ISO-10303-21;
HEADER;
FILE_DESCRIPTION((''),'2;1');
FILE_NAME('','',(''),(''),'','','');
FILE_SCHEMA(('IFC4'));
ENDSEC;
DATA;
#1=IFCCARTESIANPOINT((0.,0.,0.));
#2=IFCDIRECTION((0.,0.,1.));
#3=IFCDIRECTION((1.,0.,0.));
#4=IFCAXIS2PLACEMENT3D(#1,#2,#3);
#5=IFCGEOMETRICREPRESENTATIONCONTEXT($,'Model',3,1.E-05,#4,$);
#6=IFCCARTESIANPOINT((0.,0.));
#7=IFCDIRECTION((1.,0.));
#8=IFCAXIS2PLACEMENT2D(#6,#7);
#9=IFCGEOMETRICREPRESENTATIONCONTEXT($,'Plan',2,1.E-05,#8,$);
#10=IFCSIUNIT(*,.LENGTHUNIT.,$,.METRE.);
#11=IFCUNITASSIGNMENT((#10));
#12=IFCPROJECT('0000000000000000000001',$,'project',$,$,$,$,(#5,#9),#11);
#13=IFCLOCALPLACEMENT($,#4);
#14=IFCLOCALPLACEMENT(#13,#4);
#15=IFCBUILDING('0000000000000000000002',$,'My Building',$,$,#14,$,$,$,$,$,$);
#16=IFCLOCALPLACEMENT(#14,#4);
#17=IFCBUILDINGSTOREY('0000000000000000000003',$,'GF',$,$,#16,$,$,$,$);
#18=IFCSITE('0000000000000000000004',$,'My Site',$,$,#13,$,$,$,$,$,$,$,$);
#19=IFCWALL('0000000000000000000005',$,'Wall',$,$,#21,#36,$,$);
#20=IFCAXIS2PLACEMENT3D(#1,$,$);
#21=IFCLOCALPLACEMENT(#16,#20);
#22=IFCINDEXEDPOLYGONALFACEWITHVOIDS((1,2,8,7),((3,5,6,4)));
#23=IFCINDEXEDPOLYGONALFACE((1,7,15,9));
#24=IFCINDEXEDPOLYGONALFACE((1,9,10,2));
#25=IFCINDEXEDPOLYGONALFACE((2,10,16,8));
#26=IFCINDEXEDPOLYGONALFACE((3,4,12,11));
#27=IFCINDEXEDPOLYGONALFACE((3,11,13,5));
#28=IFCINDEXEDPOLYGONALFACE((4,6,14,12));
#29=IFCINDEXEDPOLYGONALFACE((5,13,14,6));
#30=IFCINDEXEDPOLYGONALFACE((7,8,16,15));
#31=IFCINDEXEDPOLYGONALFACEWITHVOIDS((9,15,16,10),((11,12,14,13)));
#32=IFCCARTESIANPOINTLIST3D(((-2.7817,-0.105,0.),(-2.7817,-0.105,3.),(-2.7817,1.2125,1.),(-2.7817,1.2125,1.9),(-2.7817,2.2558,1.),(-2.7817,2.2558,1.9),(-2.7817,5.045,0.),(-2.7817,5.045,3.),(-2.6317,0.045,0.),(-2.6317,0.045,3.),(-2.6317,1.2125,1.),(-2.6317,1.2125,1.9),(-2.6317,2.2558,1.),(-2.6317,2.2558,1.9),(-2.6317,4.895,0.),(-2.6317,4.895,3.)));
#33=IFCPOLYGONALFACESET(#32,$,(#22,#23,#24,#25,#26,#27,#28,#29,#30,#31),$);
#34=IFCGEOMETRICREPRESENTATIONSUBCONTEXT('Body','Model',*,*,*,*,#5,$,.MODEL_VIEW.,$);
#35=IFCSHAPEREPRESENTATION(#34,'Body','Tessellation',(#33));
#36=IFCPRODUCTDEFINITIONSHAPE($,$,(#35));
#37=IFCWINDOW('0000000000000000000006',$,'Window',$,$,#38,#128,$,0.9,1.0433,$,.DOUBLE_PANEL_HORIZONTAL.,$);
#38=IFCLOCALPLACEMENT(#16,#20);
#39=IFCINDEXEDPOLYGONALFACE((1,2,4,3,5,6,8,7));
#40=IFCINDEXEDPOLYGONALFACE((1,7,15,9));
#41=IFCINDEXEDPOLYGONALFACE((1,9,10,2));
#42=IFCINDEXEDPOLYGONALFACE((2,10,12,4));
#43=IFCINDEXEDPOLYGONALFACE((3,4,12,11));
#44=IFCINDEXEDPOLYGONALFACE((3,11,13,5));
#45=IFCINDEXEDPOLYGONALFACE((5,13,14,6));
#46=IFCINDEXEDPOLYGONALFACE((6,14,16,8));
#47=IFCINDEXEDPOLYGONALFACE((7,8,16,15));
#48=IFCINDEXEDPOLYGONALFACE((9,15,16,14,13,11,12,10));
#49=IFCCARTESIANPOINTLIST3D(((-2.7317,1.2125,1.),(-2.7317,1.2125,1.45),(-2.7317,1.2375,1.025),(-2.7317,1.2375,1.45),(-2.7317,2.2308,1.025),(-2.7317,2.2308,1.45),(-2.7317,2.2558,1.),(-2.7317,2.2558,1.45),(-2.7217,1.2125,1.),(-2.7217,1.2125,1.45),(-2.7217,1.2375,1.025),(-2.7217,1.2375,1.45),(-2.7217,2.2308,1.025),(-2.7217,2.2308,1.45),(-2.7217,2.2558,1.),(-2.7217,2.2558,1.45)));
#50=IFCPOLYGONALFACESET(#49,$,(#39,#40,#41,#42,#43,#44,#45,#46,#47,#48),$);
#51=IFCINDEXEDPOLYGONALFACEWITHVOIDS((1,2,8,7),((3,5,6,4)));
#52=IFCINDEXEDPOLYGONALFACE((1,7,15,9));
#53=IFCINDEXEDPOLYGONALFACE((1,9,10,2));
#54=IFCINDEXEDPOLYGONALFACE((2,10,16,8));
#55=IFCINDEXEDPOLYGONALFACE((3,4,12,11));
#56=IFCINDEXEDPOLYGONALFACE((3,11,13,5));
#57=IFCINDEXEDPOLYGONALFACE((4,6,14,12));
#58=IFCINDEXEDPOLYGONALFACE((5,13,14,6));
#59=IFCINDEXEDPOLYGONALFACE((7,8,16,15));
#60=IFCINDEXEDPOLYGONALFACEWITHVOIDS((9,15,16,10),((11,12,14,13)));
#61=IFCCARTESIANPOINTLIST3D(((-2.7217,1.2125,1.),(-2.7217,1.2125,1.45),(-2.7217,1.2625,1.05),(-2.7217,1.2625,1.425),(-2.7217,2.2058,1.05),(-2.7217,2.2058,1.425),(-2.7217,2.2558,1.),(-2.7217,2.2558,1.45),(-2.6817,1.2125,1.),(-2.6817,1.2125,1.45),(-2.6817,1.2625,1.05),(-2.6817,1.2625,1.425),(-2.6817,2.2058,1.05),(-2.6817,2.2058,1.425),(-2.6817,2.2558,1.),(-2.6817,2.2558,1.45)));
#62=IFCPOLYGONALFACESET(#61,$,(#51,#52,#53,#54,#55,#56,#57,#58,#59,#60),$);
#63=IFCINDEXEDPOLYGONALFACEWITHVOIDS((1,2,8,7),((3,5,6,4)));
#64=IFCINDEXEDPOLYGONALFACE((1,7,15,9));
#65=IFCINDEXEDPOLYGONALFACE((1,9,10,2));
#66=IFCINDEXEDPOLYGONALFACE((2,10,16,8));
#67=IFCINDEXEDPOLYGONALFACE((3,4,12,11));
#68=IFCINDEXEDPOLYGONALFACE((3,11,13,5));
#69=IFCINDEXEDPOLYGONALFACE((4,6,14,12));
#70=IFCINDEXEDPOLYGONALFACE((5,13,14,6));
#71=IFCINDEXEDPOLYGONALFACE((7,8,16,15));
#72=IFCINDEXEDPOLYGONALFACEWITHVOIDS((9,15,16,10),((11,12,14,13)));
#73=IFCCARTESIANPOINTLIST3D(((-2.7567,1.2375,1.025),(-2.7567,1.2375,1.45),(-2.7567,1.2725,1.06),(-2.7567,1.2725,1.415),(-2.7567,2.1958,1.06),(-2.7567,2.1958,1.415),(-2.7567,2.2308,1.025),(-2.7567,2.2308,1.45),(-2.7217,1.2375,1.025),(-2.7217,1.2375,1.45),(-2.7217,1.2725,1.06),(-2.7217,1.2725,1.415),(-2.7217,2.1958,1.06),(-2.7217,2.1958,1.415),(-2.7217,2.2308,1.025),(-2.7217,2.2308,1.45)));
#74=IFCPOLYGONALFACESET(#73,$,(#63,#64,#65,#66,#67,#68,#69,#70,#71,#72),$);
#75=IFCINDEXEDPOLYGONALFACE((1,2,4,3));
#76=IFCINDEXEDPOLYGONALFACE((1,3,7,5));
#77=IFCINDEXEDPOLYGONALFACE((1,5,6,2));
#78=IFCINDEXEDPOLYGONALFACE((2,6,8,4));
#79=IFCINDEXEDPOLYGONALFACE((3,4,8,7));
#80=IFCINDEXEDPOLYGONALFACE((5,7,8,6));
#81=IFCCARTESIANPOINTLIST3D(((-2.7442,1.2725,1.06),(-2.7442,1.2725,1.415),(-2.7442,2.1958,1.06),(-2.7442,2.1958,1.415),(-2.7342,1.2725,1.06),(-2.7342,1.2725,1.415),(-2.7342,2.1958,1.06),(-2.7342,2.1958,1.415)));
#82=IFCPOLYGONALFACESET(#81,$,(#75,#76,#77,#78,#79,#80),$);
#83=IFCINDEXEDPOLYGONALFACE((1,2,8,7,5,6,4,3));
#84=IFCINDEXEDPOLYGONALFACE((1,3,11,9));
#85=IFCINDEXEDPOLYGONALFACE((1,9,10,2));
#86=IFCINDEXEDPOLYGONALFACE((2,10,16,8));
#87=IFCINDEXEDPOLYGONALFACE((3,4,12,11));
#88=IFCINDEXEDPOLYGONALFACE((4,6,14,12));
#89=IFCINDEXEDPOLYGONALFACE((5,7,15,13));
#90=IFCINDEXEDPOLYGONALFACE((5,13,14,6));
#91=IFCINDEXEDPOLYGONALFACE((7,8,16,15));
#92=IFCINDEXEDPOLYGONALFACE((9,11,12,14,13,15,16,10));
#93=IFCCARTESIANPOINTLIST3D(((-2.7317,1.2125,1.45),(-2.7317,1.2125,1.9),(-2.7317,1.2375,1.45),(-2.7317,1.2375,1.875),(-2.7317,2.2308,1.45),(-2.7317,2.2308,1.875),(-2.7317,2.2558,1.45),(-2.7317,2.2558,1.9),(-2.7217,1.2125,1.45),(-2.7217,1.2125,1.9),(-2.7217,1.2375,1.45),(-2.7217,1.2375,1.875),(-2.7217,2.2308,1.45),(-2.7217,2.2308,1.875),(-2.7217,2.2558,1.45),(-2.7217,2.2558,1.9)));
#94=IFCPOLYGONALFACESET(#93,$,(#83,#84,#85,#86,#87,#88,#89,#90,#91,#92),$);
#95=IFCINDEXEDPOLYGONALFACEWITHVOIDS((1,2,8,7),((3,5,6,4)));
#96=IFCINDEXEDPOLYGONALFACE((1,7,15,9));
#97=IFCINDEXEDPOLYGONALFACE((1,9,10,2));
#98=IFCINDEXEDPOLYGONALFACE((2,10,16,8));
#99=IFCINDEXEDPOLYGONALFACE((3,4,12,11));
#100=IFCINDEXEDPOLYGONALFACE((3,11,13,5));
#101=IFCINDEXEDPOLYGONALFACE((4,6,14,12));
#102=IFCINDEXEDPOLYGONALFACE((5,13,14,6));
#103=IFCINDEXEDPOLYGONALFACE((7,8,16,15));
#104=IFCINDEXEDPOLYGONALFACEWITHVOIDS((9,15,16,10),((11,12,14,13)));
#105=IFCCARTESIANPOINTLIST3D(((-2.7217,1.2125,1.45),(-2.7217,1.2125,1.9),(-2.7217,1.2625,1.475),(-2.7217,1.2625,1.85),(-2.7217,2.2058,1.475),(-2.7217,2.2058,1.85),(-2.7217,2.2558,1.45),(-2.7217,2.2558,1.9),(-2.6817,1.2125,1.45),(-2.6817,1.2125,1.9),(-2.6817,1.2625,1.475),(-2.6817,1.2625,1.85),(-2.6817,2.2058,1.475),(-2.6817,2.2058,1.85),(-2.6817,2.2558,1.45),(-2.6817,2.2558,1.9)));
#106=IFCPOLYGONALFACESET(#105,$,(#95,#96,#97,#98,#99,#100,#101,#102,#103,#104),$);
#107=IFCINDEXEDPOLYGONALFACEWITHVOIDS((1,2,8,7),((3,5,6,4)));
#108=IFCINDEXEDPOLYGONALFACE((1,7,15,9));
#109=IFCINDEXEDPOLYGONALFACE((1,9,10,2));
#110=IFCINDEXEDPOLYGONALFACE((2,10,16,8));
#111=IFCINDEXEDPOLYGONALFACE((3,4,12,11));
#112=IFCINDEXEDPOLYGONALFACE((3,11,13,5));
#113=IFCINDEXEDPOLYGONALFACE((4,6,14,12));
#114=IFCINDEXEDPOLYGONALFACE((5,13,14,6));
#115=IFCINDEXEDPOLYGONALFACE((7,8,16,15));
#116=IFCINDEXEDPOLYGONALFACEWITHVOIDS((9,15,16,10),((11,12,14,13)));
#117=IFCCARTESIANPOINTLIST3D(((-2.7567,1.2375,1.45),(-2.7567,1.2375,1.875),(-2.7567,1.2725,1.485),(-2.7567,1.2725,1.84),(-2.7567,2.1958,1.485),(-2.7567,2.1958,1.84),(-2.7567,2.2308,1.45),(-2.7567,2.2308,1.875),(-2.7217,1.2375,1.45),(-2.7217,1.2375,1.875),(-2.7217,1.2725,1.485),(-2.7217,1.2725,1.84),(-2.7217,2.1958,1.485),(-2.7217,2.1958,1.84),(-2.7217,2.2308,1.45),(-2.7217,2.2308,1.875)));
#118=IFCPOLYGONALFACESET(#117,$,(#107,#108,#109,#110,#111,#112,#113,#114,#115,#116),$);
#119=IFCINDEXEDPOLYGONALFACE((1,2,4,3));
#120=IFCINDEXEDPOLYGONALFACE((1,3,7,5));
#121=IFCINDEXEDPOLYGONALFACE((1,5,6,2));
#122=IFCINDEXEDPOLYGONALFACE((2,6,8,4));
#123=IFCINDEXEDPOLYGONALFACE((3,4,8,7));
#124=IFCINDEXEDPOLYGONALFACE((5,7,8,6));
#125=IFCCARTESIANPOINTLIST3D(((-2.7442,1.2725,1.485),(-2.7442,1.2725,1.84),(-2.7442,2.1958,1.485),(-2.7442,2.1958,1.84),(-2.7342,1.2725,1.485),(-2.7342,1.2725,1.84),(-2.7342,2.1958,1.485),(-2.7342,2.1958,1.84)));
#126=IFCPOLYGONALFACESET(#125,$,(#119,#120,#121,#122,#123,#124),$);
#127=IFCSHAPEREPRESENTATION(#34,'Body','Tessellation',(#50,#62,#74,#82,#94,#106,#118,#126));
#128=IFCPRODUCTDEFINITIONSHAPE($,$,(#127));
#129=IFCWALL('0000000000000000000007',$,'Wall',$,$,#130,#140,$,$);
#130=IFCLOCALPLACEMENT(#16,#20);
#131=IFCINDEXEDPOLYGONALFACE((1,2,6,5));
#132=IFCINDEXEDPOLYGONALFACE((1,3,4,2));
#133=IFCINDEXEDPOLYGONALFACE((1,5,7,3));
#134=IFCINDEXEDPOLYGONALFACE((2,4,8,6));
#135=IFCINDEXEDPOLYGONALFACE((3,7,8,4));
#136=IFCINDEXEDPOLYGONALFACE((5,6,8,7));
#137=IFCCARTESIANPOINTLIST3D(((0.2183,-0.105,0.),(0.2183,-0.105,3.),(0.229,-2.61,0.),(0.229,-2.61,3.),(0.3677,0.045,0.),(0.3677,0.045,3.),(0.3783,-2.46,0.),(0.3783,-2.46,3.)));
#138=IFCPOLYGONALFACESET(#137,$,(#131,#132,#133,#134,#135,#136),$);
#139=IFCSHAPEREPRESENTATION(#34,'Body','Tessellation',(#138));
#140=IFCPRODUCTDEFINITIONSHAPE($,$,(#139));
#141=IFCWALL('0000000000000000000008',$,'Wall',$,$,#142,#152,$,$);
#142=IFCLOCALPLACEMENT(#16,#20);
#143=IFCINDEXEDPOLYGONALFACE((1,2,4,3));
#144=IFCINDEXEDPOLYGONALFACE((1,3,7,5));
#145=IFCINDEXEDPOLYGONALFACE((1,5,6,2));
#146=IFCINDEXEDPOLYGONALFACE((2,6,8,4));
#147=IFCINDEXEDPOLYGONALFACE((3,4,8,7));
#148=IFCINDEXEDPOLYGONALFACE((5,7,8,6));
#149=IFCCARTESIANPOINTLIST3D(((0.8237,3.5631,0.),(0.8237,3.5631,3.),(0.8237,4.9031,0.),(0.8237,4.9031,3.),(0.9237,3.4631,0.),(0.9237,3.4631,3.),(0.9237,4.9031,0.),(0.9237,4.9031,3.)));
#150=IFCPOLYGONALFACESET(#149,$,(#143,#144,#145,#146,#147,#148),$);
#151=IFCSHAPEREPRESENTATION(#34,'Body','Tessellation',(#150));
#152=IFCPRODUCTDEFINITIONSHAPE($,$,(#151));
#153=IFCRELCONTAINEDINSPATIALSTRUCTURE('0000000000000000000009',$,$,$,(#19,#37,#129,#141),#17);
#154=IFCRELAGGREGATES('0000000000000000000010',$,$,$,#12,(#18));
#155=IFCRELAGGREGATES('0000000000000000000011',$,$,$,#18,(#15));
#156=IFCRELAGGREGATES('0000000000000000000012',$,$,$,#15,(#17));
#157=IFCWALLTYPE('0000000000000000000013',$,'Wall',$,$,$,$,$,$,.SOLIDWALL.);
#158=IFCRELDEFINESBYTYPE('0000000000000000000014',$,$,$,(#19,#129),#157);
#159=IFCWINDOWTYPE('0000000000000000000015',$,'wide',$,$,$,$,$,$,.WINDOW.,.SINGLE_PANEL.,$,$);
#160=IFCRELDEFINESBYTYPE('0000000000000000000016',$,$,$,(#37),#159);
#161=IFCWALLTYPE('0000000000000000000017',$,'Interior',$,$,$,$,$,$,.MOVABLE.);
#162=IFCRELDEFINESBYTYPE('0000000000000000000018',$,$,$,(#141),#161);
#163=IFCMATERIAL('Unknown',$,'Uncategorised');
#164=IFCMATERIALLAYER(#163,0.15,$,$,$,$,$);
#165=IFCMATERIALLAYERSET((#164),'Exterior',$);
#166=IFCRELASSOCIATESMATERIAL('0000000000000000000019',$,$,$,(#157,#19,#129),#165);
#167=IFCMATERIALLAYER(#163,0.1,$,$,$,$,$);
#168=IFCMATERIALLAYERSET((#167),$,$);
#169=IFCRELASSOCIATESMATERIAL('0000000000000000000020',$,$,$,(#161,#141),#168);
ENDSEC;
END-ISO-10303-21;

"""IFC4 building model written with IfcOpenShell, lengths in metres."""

from ifc_helpers import new_model, entity, si_unit, frame, origin_with_axes, origin_2d_with_axis, place, context, subcontext, project, spatial, line, indexed_curve, outline, extrude, shape, source, transform, mapped, material, layer, layer_set, layer_usage, type_object, type_shapes, element, fill, save


model = new_model("IFC4")

# Units and contexts
model_context = context("Model", 3, precision=1e-05, world=origin_with_axes())
plan_context = context("Plan", 2, precision=1e-05, world=origin_2d_with_axis())
body_context_1 = subcontext(model_context, "Body", "Model", "MODEL_VIEW")
body_context_2 = subcontext(plan_context, "Body", "Plan", "PLAN_VIEW")
ifc_project = project(units=[si_unit("LENGTHUNIT", "METRE")], contexts=[model_context, plan_context])

# Site, building, storey
site_placement = place(None, origin_with_axes())
site = spatial("IfcSite", under=ifc_project, at=site_placement, Name="My Site")
building_placement = place(site_placement, origin_with_axes())
building = spatial("IfcBuilding", under=site, at=building_placement, Name="My Building")
storey_placement = place(building_placement, origin_with_axes())
storey = spatial("IfcBuildingStorey", under=building, at=storey_placement, Name="GF")

# Shared definitions
ifc_material = material(Name="Unknown", Category="Uncategorised")

# Shared definitions
ifc_layer_1 = layer(ifc_material, 0.15)
ifc_layer_set_1 = layer_set([ifc_layer_1], Name="Exterior")
wall_type_1 = type_object("IfcWallType", Name="Wall", PredefinedType="SOLIDWALL", material=ifc_layer_set_1)
shared_shape_1 = source(origin_with_axes(), body_context_1, "Body", "SweptSolid", [
    extrude(outline(indexed_curve([(0.0, 0.0), (1.0433, 0.0), (1.0433, 0.9), (0.0, 0.9)], segments=[line(1, 2, 3, 4, 1)])), frame((0.0, -0.6, 0.0), z_axis=(0.0, -1.0, 0.0), x_axis=(1.0, 0.0, 0.0)), (0.0, 0.0, -1.0), 1.2),
])
window_type_1 = type_object("IfcWindowType", Name="wide", PartitioningType="SINGLE_PANEL", PredefinedType="WINDOW")
shared_shape_2 = source(origin_with_axes(), body_context_1, "Body", "SweptSolid", [
    extrude(outline(indexed_curve([(1.0433, 0.45), (1.0433, 0.0), (0.0, 0.0), (0.0, 0.45), (0.025, 0.45), (0.025, 0.025), (1.0183, 0.025), (1.0183, 0.45)], segments=[line(1, 2, 3, 4, 5, 6, 7, 8, 1)])), frame((0.0, 0.09, 0.0), z_axis=(0.0, -1.0, 0.0), x_axis=(1.0, 0.0, 0.0)), (0.0, 0.0, -1.0), 0.01),
    extrude(outline(indexed_curve([(0.0, 0.0), (1.0433, 0.0), (1.0433, 0.45), (0.0, 0.45)], segments=[line(1, 2, 3, 4, 1)]), holes=[indexed_curve([(0.05, 0.05), (0.9933, 0.05), (0.9933, 0.425), (0.05, 0.425)], segments=[line(1, 2, 3, 4, 1)])]), frame((0.0, 0.05, 0.0), z_axis=(0.0, -1.0, 0.0), x_axis=(1.0, 0.0, 0.0)), (0.0, 0.0, -1.0), 0.04),
    extrude(outline(indexed_curve([(0.0, 0.0), (0.9933, 0.0), (0.9933, 0.425), (0.0, 0.425)], segments=[line(1, 2, 3, 4, 1)]), holes=[indexed_curve([(0.035, 0.035), (0.9583, 0.035), (0.9583, 0.39), (0.035, 0.39)], segments=[line(1, 2, 3, 4, 1)])]), frame((0.025, 0.09, 0.025), z_axis=(0.0, -1.0, 0.0), x_axis=(1.0, 0.0, 0.0)), (0.0, 0.0, -1.0), 0.035),
    extrude(outline(indexed_curve([(0.035, 0.035), (0.9583, 0.035), (0.9583, 0.39), (0.035, 0.39)], segments=[line(1, 2, 3, 4, 1)])), frame((0.025, 0.1025, 0.025), z_axis=(0.0, -1.0, 0.0), x_axis=(1.0, 0.0, 0.0)), (0.0, 0.0, -1.0), 0.01),
    extrude(outline(indexed_curve([(0.0, 0.0), (0.0, 0.45), (1.0433, 0.45), (1.0433, 0.0), (1.0183, 0.0), (1.0183, 0.425), (0.025, 0.425), (0.025, 0.0)], segments=[line(1, 2, 3, 4, 5, 6, 7, 8, 1)])), frame((0.0, 0.09, 0.45), z_axis=(0.0, -1.0, 0.0), x_axis=(1.0, 0.0, 0.0)), (0.0, 0.0, -1.0), 0.01),
    extrude(outline(indexed_curve([(0.0, 0.0), (1.0433, 0.0), (1.0433, 0.45), (0.0, 0.45)], segments=[line(1, 2, 3, 4, 1)]), holes=[indexed_curve([(0.05, 0.025), (0.9933, 0.025), (0.9933, 0.4), (0.05, 0.4)], segments=[line(1, 2, 3, 4, 1)])]), frame((0.0, 0.05, 0.45), z_axis=(0.0, -1.0, 0.0), x_axis=(1.0, 0.0, 0.0)), (0.0, 0.0, -1.0), 0.04),
    extrude(outline(indexed_curve([(0.0, 0.0), (0.9933, 0.0), (0.9933, 0.425), (0.0, 0.425)], segments=[line(1, 2, 3, 4, 1)]), holes=[indexed_curve([(0.035, 0.035), (0.9583, 0.035), (0.9583, 0.39), (0.035, 0.39)], segments=[line(1, 2, 3, 4, 1)])]), frame((0.025, 0.09, 0.45), z_axis=(0.0, -1.0, 0.0), x_axis=(1.0, 0.0, 0.0)), (0.0, 0.0, -1.0), 0.035),
    extrude(outline(indexed_curve([(0.035, 0.035), (0.9583, 0.035), (0.9583, 0.39), (0.035, 0.39)], segments=[line(1, 2, 3, 4, 1)])), frame((0.025, 0.1025, 0.45), z_axis=(0.0, -1.0, 0.0), x_axis=(1.0, 0.0, 0.0)), (0.0, 0.0, -1.0), 0.01),
])
shared_shape_3 = source(origin_with_axes(), body_context_2, "Body", "Curve2D", [
    entity("IfcIndexedPolyCurve", entity("IfcCartesianPointList2D", [[0.05, 0.05], [0.9933, 0.05]])),
    entity("IfcIndexedPolyCurve", entity("IfcCartesianPointList2D", [[0.0, 0.1], [0.025, 0.1], [0.025, 0.09], [0.05, 0.09], [0.05, 0.05], [0.0, 0.05]]), [entity("IfcLineIndex", [1, 2, 3, 4, 5, 6, 1])]),
    entity("IfcIndexedPolyCurve", entity("IfcCartesianPointList2D", [[1.0433, 0.1], [1.0183, 0.1], [1.0183, 0.09], [0.9933, 0.09], [0.9933, 0.05], [1.0433, 0.05]]), [entity("IfcLineIndex", [1, 2, 3, 4, 5, 6, 1])]),
    entity("IfcIndexedPolyCurve", entity("IfcCartesianPointList2D", [[0.025, 0.09], [0.06, 0.09], [0.06, 0.125], [0.025, 0.125]]), [entity("IfcLineIndex", [1, 2, 3, 4, 1])]),
    entity("IfcIndexedPolyCurve", entity("IfcCartesianPointList2D", [[1.0183, 0.09], [0.9833, 0.09], [0.9833, 0.125], [1.0183, 0.125]]), [entity("IfcLineIndex", [1, 2, 3, 4, 1])]),
    entity("IfcIndexedPolyCurve", entity("IfcCartesianPointList2D", [[0.06, 0.09], [0.9833, 0.09]])),
    entity("IfcIndexedPolyCurve", entity("IfcCartesianPointList2D", [[0.06, 0.125], [0.9833, 0.125]])),
    entity("IfcIndexedPolyCurve", entity("IfcCartesianPointList2D", [[0.06, 0.1075], [0.9833, 0.1075]])),
])
type_shapes(window_type_1, [shared_shape_2, shared_shape_3])

# Wall, opening, window
ifc_layer_usage_1 = layer_usage(ifc_layer_set_1, "AXIS2", "POSITIVE", 0.0)
wall_1_placement = place(storey_placement, frame((-2.7817, 5.045, 0.0), z_axis=(0.0, 0.0, 1.0), x_axis=(0.0, -1.0, 0.0)))
wall_1 = element("IfcWall", 1, at=wall_1_placement, inside=storey, type_object=wall_type_1, material=ifc_layer_usage_1, Name="Wall", context=body_context_1, shape_type="SweptSolid", body=[
    extrude(outline(indexed_curve([(0.0, 0.0), (0.15, 0.15), (5.0, 0.15), (5.15, 0.0)], segments=[line(1, 2, 3, 4, 1)])), origin_with_axes(), (0.0, 0.0, 1.0), 3.0),
])
opening_1_placement = place(wall_1_placement, frame((3.8324, 0.15, 1.0), z_axis=(0.0, 0.0, 1.0), x_axis=(-1.0, 0.0, 0.0)))
opening_1 = element("IfcOpeningElement", 2, at=opening_1_placement, cuts=wall_1, PredefinedType="OPENING", context=body_context_1, shape_type="MappedRepresentation", body=[
    mapped(shared_shape_1, transform((0.0, 0.0, 0.0), x_axis=(1.0, 0.0, 0.0), y_axis=(0.0, 1.0, 0.0), z_axis=(0.0, 0.0, 1.0), scale=1.0)),
])
window_1_placement = place(opening_1_placement, frame((0.0, 0.0, 0.0), z_axis=(0.0, 0.0, 1.0), x_axis=(1.0, 0.0, 0.0)))
window_1 = element("IfcWindow", 3, at=window_1_placement, inside=storey, type_object=window_type_1, Name="Window", OverallHeight=0.9, OverallWidth=1.0433, PartitioningType="DOUBLE_PANEL_HORIZONTAL", shapes=[
    shape(body_context_1, "Body", "MappedRepresentation", [mapped(shared_shape_2, transform((0.0, 0.0, 0.0), x_axis=(1.0, 0.0, 0.0), y_axis=(0.0, 1.0, 0.0), z_axis=(0.0, 0.0, 1.0), scale=1.0))]),
    shape(body_context_2, "Body", "MappedRepresentation", [mapped(shared_shape_3, transform((0.0, 0.0, 0.0), x_axis=(1.0, 0.0, 0.0), y_axis=(0.0, 1.0, 0.0), z_axis=(0.0, 0.0, 1.0), scale=1.0))]),
])
fill(opening_1, window_1)

# Walls
ifc_layer_usage_2 = layer_usage(ifc_layer_set_1, "AXIS2", "POSITIVE", 0.0)
wall_2_placement = place(storey_placement, frame((0.2183, -0.105, 0.0), z_axis=(0.0, 0.0, 1.0), x_axis=(0.004245, -0.999991, 0.0)))
element("IfcWall", 4, at=wall_2_placement, inside=storey, type_object=wall_type_1, material=ifc_layer_usage_2, Name="Wall", context=body_context_1, shape_type="SweptSolid", body=[
    extrude(outline(indexed_curve([(0.0, 0.0), (-0.1494, 0.15), (2.3557, 0.15), (2.505, 0.0)], segments=[line(1, 2, 3, 4, 1)])), origin_with_axes(), (0.0, 0.0, 1.0), 3.0),
])
ifc_layer_2 = layer(ifc_material, 0.1)
ifc_layer_set_2 = layer_set([ifc_layer_2])
ifc_layer_usage_3 = layer_usage(ifc_layer_set_2, "AXIS2", "POSITIVE", 0.0)
wall_type_2 = type_object("IfcWallType", Name="Interior", PredefinedType="MOVABLE", material=ifc_layer_set_2)
wall_3_placement = place(storey_placement, frame((0.8237, 4.9031, 0.0), z_axis=(0.0, 0.0, 1.0), x_axis=(0.0, -1.0, 0.0)))
element("IfcWall", 5, at=wall_3_placement, inside=storey, type_object=wall_type_2, material=ifc_layer_usage_3, Name="Wall", context=body_context_1, shape_type="SweptSolid", body=[
    extrude(outline(indexed_curve([(0.0, 0.0), (0.0, 0.1), (1.44, 0.1), (1.34, 0.0)], segments=[line(1, 2, 3, 4, 1)])), origin_with_axes(), (0.0, 0.0, 1.0), 3.0),
])

save(model, "model.ifc")
